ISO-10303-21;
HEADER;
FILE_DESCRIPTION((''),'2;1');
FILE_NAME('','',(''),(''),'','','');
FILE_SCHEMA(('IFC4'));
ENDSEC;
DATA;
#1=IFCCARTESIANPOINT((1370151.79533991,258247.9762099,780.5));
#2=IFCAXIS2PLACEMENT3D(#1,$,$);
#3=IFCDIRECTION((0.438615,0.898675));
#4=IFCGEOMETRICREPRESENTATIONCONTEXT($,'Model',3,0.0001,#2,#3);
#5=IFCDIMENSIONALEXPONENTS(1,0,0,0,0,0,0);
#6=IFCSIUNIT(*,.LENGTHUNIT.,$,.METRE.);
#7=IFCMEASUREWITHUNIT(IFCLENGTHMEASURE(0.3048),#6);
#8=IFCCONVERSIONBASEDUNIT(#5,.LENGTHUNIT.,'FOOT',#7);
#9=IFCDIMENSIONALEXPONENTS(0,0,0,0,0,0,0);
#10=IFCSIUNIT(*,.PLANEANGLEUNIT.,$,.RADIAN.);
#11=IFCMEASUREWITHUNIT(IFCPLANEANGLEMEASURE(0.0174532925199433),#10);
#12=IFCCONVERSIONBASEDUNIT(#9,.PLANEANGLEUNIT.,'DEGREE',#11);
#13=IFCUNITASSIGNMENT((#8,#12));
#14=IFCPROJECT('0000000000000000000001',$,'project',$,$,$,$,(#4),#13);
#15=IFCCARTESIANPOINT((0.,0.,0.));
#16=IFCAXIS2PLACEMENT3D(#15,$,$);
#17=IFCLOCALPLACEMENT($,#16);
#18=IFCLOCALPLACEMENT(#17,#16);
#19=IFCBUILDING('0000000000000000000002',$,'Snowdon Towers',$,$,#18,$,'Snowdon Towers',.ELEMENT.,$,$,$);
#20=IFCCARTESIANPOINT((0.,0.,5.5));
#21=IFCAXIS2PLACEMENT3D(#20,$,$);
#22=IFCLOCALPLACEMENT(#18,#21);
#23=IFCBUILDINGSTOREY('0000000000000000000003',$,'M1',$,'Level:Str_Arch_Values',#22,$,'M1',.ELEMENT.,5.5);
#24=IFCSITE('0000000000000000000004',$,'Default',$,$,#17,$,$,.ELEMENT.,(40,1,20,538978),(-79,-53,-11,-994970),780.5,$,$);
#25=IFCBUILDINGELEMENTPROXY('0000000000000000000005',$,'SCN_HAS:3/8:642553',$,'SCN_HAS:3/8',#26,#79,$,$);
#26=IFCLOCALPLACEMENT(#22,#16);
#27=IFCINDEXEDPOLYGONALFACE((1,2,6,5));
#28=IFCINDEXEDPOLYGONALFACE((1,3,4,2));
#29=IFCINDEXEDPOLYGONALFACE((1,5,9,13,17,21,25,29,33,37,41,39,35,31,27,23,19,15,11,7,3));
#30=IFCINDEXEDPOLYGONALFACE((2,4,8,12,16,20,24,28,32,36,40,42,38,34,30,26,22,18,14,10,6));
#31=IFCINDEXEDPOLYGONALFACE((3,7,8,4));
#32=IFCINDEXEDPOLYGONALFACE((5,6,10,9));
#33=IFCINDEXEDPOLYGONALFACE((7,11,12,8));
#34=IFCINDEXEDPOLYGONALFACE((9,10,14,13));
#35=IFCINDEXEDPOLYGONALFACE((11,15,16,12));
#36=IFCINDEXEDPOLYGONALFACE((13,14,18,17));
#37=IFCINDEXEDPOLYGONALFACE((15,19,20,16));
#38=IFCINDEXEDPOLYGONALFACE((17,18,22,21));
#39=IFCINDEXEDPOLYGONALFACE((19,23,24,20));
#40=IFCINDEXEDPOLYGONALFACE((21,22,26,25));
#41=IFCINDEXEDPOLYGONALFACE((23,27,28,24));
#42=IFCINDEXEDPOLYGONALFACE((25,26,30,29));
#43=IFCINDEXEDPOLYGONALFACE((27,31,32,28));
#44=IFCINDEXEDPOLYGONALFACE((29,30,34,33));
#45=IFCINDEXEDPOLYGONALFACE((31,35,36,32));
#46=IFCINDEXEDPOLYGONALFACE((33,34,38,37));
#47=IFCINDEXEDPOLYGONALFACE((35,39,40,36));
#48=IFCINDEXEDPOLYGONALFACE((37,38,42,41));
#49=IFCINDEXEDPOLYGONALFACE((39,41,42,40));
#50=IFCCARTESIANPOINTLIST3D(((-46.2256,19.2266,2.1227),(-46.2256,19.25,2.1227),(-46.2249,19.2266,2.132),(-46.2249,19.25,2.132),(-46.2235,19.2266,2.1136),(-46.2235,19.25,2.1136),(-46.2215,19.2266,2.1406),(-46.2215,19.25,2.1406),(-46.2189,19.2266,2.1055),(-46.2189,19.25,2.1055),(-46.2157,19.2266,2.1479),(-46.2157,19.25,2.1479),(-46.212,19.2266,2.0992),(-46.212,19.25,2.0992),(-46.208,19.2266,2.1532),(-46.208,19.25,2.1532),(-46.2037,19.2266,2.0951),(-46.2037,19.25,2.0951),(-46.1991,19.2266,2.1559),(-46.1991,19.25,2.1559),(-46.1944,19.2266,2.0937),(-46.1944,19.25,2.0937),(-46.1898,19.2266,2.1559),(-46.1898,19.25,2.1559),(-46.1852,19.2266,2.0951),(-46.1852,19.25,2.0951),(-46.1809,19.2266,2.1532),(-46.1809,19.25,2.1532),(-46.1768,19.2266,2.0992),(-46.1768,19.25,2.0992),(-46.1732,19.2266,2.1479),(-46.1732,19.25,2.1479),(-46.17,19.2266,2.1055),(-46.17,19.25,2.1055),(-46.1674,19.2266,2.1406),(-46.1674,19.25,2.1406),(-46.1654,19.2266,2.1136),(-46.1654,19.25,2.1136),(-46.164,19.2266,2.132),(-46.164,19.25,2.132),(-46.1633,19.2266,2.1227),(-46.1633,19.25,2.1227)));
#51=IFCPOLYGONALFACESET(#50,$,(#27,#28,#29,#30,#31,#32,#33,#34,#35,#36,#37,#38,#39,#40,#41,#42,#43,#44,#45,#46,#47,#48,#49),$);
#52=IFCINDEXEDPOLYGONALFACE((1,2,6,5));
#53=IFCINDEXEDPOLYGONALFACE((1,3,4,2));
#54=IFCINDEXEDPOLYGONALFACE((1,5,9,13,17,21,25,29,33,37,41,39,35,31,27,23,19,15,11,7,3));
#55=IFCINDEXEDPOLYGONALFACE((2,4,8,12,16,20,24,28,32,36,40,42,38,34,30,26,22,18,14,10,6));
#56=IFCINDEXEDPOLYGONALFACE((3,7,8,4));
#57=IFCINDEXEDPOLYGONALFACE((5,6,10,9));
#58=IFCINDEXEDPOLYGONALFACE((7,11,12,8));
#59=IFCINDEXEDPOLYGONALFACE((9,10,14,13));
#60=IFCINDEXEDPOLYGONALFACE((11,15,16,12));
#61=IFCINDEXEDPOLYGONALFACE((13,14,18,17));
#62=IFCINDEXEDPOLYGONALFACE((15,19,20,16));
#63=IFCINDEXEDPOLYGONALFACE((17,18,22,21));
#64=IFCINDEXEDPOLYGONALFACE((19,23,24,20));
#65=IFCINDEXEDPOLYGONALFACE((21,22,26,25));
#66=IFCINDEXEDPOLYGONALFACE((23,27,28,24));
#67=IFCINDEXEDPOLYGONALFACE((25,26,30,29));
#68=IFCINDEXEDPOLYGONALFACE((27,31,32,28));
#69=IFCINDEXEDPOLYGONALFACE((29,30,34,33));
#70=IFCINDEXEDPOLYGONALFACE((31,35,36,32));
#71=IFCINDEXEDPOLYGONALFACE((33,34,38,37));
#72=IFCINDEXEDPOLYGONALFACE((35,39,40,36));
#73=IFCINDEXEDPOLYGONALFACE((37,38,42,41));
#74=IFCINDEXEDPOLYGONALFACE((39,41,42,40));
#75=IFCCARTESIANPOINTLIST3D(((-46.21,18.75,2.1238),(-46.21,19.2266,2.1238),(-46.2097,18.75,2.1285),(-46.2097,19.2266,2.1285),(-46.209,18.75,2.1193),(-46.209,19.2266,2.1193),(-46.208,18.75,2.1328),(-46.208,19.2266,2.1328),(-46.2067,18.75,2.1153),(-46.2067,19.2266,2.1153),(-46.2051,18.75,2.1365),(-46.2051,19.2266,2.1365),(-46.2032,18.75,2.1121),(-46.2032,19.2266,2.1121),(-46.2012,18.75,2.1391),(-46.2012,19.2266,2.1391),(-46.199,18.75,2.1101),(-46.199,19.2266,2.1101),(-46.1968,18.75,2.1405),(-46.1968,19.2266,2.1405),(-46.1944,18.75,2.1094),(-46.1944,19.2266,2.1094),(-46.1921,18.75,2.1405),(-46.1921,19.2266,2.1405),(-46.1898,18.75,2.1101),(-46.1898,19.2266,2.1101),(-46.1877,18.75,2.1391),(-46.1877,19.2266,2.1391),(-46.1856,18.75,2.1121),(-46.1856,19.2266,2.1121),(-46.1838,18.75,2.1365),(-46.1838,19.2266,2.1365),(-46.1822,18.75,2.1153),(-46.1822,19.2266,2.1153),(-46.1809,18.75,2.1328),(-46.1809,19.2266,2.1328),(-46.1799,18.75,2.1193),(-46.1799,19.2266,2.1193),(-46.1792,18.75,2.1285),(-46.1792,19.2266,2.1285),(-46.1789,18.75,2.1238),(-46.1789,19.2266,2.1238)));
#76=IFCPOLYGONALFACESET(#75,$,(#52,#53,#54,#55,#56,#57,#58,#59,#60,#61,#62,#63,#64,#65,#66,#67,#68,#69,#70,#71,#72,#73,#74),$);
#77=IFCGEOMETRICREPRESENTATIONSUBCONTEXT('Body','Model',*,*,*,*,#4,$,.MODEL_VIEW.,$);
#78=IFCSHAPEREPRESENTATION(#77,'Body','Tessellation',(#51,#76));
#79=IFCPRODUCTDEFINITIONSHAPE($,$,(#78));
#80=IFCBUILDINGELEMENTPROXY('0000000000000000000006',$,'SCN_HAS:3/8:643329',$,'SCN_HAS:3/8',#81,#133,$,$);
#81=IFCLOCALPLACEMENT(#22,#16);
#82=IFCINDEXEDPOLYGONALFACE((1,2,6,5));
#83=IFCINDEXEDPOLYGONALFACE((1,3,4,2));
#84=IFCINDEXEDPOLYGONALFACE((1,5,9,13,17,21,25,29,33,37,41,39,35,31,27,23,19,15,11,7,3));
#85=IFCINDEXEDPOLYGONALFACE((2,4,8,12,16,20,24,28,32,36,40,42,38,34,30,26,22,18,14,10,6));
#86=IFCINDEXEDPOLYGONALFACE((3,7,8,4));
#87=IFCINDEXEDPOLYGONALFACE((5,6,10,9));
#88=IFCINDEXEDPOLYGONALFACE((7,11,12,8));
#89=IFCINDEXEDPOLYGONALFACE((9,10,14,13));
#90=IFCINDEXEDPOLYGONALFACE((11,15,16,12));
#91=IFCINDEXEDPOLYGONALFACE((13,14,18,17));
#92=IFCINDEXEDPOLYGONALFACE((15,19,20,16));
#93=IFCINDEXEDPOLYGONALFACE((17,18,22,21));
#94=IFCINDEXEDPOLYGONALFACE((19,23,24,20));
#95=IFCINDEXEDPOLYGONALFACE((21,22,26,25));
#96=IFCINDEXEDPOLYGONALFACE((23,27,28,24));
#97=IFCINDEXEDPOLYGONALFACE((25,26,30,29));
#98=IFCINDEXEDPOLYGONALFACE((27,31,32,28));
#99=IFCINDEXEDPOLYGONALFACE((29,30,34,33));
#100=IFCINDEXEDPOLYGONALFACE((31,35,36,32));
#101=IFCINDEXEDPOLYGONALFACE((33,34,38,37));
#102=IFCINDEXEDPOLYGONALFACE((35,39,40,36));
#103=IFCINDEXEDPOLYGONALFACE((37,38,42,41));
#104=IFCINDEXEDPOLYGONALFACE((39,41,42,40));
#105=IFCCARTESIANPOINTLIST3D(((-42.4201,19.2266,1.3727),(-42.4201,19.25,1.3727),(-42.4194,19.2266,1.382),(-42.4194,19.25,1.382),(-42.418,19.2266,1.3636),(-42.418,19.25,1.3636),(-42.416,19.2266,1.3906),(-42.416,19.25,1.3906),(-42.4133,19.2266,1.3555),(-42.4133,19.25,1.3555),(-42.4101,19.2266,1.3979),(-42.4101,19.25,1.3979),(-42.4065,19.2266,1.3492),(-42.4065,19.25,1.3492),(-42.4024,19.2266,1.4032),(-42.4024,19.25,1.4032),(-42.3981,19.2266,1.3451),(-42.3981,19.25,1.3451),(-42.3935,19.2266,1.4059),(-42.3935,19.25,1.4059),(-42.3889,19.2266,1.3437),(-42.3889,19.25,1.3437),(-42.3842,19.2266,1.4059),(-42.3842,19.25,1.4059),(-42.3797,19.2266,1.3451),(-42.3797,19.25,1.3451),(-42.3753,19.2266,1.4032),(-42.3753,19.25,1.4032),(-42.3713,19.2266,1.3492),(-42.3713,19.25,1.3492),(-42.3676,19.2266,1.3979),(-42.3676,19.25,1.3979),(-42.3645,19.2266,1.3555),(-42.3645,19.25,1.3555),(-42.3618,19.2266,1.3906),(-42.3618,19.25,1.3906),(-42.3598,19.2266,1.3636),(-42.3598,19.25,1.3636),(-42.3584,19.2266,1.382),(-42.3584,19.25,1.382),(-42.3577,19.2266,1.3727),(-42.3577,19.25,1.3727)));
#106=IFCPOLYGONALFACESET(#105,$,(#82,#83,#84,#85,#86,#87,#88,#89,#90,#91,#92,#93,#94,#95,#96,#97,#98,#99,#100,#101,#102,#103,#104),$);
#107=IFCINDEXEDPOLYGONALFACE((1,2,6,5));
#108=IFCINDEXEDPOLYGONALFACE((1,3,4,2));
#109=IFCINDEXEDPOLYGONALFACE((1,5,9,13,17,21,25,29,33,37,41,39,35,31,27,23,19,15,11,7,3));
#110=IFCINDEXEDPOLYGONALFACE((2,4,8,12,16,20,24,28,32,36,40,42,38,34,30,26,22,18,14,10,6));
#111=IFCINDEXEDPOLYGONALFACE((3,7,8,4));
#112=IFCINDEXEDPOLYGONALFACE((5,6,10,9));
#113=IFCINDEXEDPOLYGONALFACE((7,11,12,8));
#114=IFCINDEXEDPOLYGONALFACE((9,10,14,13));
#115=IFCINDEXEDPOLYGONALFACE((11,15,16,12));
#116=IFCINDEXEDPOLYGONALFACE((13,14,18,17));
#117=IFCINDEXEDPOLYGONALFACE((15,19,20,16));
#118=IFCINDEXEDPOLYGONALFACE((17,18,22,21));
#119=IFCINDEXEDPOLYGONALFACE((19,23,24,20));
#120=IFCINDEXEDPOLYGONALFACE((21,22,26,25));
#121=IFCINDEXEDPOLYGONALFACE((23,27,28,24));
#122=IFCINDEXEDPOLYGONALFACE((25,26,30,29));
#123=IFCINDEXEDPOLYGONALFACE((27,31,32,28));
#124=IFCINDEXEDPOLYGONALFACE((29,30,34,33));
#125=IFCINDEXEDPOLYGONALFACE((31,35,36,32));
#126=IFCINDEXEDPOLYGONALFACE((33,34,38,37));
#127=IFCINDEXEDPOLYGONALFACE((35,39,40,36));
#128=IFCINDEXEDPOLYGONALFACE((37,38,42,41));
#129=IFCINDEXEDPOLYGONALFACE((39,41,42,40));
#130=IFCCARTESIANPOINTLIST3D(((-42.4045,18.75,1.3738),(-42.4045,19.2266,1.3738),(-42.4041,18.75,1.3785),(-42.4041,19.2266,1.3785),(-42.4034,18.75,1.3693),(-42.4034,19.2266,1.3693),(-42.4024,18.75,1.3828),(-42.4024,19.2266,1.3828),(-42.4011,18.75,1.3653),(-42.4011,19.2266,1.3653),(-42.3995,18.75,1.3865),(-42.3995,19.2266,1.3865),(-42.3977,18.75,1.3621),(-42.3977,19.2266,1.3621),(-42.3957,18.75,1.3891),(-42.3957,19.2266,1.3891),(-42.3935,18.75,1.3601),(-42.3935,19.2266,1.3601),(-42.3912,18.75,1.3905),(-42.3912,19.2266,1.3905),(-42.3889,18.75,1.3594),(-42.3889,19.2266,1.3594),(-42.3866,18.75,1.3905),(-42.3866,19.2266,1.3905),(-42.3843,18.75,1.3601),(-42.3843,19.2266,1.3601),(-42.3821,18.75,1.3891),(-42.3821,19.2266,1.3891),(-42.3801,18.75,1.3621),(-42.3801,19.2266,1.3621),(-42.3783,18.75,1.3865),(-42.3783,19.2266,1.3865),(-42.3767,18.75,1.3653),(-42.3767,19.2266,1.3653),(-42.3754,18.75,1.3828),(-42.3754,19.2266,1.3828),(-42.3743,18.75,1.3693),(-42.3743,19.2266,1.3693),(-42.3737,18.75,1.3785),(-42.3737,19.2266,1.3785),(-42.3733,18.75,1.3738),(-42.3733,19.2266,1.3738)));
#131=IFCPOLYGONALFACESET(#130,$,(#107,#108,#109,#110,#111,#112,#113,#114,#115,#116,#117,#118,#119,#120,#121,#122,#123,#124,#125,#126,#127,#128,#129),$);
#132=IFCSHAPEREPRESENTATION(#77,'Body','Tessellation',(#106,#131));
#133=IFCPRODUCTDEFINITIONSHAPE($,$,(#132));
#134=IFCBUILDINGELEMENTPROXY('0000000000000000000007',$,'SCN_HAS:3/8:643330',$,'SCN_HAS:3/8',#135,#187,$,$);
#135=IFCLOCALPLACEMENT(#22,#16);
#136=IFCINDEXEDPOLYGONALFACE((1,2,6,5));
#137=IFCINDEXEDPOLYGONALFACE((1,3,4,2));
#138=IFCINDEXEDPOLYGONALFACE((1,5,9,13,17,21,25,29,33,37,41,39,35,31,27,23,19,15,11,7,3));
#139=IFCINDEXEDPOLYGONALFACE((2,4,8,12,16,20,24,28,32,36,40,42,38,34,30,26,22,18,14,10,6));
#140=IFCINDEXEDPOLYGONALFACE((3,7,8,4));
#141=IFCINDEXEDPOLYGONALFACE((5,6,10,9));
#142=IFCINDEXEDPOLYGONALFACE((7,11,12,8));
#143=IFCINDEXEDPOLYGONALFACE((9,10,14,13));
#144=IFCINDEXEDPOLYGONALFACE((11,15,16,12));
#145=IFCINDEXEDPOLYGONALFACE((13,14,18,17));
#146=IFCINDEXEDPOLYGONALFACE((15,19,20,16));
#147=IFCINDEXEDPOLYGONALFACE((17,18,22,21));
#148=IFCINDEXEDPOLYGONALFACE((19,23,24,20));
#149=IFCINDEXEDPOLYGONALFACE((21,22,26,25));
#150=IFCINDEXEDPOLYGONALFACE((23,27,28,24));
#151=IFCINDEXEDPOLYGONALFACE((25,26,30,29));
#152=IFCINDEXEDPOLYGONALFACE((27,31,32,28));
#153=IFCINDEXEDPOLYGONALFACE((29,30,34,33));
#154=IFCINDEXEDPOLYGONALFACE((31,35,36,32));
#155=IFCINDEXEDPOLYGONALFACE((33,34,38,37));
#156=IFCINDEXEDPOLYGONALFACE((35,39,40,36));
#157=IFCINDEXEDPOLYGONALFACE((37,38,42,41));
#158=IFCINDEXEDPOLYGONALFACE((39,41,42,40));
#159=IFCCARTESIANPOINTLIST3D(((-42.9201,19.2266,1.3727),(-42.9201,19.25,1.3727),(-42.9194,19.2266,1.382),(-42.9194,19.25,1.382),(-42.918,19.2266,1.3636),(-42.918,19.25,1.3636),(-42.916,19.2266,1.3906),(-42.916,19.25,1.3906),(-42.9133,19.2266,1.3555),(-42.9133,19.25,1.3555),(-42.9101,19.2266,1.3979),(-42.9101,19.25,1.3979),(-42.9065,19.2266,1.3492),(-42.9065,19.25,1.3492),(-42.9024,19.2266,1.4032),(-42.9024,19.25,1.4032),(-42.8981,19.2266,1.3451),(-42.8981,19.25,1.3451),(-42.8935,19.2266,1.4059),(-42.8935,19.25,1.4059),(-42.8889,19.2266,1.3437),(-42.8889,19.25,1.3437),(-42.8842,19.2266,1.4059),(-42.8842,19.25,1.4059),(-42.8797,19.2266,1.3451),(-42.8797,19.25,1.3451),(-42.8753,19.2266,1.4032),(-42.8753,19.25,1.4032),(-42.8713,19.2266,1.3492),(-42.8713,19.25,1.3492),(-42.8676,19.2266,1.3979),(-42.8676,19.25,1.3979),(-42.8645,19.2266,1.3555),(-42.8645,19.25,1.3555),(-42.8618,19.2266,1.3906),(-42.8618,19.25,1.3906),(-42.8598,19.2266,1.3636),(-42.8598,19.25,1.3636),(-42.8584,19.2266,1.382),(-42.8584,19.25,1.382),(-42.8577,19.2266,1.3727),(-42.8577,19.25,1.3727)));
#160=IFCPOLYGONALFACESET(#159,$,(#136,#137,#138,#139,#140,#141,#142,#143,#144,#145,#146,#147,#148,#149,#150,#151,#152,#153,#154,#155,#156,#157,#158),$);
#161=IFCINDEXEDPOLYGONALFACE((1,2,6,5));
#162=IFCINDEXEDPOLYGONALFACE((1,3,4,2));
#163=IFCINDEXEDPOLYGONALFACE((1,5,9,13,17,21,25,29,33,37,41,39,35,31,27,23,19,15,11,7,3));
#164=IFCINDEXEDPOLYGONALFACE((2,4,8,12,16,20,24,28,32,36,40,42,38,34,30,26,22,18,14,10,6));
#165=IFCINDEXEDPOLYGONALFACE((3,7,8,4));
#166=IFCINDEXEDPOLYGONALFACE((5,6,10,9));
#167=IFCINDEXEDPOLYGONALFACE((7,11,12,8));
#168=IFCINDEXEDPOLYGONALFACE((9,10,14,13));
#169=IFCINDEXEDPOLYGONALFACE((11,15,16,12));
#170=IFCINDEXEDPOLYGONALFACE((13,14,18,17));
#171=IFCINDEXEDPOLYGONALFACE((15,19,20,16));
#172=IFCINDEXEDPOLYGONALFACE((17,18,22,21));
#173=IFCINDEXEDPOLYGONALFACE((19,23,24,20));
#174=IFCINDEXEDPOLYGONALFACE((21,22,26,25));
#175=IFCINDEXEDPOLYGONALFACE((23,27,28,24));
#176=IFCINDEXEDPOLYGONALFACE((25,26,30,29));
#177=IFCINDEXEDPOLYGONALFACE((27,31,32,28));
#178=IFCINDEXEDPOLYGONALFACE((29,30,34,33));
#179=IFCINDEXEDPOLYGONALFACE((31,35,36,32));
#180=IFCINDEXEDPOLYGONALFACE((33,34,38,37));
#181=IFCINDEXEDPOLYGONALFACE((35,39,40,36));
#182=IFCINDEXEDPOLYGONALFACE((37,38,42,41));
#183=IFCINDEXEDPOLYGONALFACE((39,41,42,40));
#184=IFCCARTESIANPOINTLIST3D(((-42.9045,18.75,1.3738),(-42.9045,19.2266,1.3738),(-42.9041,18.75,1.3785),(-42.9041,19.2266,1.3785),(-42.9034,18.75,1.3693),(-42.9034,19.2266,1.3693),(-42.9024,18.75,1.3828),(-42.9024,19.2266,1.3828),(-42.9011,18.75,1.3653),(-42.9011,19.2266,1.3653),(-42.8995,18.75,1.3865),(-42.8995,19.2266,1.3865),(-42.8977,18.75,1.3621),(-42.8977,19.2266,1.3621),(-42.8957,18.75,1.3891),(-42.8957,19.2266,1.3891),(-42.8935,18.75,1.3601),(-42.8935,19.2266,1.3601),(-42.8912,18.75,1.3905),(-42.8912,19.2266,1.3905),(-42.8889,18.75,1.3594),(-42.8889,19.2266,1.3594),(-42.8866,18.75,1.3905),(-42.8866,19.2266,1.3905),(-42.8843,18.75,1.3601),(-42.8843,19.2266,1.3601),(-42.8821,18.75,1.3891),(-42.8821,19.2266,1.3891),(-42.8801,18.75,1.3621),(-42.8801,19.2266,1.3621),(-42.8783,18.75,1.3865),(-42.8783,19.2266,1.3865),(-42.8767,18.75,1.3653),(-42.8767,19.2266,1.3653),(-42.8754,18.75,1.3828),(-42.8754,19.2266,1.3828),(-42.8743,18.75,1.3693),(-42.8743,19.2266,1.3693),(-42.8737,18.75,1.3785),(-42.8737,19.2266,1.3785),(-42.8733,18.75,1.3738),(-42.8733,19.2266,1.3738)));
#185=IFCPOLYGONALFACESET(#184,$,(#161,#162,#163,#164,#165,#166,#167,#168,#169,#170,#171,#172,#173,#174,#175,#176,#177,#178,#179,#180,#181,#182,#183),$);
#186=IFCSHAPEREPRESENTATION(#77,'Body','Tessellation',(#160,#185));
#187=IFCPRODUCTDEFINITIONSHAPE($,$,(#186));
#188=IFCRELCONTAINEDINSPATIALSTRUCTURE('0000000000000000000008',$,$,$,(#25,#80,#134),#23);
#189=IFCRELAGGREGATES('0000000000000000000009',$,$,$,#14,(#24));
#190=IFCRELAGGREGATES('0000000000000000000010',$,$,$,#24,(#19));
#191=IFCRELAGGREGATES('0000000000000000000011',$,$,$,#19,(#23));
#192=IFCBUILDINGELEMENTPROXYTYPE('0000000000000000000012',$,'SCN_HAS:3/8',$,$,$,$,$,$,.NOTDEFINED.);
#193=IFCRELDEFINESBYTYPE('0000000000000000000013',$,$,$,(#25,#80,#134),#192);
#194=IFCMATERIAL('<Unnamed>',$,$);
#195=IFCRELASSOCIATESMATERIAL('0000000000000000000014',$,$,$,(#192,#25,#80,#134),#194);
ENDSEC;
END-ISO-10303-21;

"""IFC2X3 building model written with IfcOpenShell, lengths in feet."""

from ifc_helpers import new_model, entity, si_unit, converted_unit, direction, frame, frame_2d, origin, place, context, subcontext, project, spatial, circle, extrude, source, transform, mapped, material, type_object, type_shapes, element, save


model = new_model("IFC2X3")

# Units and contexts
model_context = context("Model", 3, precision=0.0001, world=frame((1370151.79533991, 258247.9762099, 780.5)), true_north=direction((0.438615, 0.898675)))
body_context = subcontext(model_context, "Body", "Model", "MODEL_VIEW")
ifc_project = project(units=[converted_unit("LENGTHUNIT", "FOOT", entity("IfcLengthMeasure", 0.3048), si_unit("LENGTHUNIT", "METRE"), dimensions=[1, 0, 0, 0, 0, 0, 0]), converted_unit("PLANEANGLEUNIT", "DEGREE", entity("IfcPlaneAngleMeasure", 0.0174532925199433), si_unit("PLANEANGLEUNIT", "RADIAN"), dimensions=[0, 0, 0, 0, 0, 0, 0])], contexts=[model_context])

# Site, building, storey
site_placement = place(None, origin())
site = spatial("IfcSite", under=ifc_project, at=site_placement, Name="Default", CompositionType="ELEMENT", RefLatitude=(40, 1, 20, 538978), RefLongitude=(-79, -53, -11, -994970), RefElevation=780.5)
building_placement = place(site_placement, origin())
building = spatial("IfcBuilding", under=site, at=building_placement, Name="Snowdon Towers", LongName="Snowdon Towers", CompositionType="ELEMENT")
storey_placement = place(building_placement, frame((0.0, 0.0, 5.5)))
storey = spatial("IfcBuildingStorey", under=building, at=storey_placement, Name="M1", ObjectType="Level:Str_Arch_Values", LongName="M1", CompositionType="ELEMENT", Elevation=5.5)

# Building element proxies
ifc_material_1 = material(Name="<Unnamed>")
building_element_proxy_type = type_object("IfcBuildingElementProxyType", Name="SCN_HAS:3/8", PredefinedType="NOTDEFINED", material=ifc_material_1)
shared_shape = source(origin(), body_context, "Body", "SweptSolid", [
    extrude(circle(Radius=0.0312, at=frame_2d((0.0, 0.0), x_axis=(1.0, 0.0))), frame((0.0, 0.0, -0.5), z_axis=(0.0, 0.0, 1.0), x_axis=(0.0, -1.0, 0.0)), (0.0, 0.0, 1.0), 0.0234),
    extrude(circle(Radius=0.0156, at=frame_2d((0.0, 0.0), x_axis=(1.0, 0.0))), frame((0.0, 0.0, -0.4766), z_axis=(0.0, 0.0, 1.0), x_axis=(0.0, -1.0, 0.0)), (0.0, 0.0, 1.0), 0.4766),
])
type_shapes(building_element_proxy_type, [shared_shape])
for number, where, z_axis, x_axis, name in (
    (1, (-46.1944, 18.75, 2.125), (0.0, -1.0, 0.0), (1.0, 0.0, 0.0), "SCN_HAS:3/8:642553"),
    (2, (-42.3889, 18.75, 1.375), (0.0, -1.0, 0.0), (1.0, 0.0, 0.0), "SCN_HAS:3/8:643329"),
    (3, (-42.8889, 18.75, 1.375), (0.0, -1.0, 0.0), (1.0, 0.0, 0.0), "SCN_HAS:3/8:643330"),
):
    element("IfcBuildingElementProxy", number, at=place(storey_placement, frame(where, z_axis=z_axis, x_axis=x_axis)), inside=storey, type_object=building_element_proxy_type, material=ifc_material_1, Name=name, ObjectType="SCN_HAS:3/8", context=body_context, shape_type="MappedRepresentation", body=[
        mapped(shared_shape, transform((0.0, 0.0, 0.0), scale=1.0)),
    ])

save(model, "model.ifc")
